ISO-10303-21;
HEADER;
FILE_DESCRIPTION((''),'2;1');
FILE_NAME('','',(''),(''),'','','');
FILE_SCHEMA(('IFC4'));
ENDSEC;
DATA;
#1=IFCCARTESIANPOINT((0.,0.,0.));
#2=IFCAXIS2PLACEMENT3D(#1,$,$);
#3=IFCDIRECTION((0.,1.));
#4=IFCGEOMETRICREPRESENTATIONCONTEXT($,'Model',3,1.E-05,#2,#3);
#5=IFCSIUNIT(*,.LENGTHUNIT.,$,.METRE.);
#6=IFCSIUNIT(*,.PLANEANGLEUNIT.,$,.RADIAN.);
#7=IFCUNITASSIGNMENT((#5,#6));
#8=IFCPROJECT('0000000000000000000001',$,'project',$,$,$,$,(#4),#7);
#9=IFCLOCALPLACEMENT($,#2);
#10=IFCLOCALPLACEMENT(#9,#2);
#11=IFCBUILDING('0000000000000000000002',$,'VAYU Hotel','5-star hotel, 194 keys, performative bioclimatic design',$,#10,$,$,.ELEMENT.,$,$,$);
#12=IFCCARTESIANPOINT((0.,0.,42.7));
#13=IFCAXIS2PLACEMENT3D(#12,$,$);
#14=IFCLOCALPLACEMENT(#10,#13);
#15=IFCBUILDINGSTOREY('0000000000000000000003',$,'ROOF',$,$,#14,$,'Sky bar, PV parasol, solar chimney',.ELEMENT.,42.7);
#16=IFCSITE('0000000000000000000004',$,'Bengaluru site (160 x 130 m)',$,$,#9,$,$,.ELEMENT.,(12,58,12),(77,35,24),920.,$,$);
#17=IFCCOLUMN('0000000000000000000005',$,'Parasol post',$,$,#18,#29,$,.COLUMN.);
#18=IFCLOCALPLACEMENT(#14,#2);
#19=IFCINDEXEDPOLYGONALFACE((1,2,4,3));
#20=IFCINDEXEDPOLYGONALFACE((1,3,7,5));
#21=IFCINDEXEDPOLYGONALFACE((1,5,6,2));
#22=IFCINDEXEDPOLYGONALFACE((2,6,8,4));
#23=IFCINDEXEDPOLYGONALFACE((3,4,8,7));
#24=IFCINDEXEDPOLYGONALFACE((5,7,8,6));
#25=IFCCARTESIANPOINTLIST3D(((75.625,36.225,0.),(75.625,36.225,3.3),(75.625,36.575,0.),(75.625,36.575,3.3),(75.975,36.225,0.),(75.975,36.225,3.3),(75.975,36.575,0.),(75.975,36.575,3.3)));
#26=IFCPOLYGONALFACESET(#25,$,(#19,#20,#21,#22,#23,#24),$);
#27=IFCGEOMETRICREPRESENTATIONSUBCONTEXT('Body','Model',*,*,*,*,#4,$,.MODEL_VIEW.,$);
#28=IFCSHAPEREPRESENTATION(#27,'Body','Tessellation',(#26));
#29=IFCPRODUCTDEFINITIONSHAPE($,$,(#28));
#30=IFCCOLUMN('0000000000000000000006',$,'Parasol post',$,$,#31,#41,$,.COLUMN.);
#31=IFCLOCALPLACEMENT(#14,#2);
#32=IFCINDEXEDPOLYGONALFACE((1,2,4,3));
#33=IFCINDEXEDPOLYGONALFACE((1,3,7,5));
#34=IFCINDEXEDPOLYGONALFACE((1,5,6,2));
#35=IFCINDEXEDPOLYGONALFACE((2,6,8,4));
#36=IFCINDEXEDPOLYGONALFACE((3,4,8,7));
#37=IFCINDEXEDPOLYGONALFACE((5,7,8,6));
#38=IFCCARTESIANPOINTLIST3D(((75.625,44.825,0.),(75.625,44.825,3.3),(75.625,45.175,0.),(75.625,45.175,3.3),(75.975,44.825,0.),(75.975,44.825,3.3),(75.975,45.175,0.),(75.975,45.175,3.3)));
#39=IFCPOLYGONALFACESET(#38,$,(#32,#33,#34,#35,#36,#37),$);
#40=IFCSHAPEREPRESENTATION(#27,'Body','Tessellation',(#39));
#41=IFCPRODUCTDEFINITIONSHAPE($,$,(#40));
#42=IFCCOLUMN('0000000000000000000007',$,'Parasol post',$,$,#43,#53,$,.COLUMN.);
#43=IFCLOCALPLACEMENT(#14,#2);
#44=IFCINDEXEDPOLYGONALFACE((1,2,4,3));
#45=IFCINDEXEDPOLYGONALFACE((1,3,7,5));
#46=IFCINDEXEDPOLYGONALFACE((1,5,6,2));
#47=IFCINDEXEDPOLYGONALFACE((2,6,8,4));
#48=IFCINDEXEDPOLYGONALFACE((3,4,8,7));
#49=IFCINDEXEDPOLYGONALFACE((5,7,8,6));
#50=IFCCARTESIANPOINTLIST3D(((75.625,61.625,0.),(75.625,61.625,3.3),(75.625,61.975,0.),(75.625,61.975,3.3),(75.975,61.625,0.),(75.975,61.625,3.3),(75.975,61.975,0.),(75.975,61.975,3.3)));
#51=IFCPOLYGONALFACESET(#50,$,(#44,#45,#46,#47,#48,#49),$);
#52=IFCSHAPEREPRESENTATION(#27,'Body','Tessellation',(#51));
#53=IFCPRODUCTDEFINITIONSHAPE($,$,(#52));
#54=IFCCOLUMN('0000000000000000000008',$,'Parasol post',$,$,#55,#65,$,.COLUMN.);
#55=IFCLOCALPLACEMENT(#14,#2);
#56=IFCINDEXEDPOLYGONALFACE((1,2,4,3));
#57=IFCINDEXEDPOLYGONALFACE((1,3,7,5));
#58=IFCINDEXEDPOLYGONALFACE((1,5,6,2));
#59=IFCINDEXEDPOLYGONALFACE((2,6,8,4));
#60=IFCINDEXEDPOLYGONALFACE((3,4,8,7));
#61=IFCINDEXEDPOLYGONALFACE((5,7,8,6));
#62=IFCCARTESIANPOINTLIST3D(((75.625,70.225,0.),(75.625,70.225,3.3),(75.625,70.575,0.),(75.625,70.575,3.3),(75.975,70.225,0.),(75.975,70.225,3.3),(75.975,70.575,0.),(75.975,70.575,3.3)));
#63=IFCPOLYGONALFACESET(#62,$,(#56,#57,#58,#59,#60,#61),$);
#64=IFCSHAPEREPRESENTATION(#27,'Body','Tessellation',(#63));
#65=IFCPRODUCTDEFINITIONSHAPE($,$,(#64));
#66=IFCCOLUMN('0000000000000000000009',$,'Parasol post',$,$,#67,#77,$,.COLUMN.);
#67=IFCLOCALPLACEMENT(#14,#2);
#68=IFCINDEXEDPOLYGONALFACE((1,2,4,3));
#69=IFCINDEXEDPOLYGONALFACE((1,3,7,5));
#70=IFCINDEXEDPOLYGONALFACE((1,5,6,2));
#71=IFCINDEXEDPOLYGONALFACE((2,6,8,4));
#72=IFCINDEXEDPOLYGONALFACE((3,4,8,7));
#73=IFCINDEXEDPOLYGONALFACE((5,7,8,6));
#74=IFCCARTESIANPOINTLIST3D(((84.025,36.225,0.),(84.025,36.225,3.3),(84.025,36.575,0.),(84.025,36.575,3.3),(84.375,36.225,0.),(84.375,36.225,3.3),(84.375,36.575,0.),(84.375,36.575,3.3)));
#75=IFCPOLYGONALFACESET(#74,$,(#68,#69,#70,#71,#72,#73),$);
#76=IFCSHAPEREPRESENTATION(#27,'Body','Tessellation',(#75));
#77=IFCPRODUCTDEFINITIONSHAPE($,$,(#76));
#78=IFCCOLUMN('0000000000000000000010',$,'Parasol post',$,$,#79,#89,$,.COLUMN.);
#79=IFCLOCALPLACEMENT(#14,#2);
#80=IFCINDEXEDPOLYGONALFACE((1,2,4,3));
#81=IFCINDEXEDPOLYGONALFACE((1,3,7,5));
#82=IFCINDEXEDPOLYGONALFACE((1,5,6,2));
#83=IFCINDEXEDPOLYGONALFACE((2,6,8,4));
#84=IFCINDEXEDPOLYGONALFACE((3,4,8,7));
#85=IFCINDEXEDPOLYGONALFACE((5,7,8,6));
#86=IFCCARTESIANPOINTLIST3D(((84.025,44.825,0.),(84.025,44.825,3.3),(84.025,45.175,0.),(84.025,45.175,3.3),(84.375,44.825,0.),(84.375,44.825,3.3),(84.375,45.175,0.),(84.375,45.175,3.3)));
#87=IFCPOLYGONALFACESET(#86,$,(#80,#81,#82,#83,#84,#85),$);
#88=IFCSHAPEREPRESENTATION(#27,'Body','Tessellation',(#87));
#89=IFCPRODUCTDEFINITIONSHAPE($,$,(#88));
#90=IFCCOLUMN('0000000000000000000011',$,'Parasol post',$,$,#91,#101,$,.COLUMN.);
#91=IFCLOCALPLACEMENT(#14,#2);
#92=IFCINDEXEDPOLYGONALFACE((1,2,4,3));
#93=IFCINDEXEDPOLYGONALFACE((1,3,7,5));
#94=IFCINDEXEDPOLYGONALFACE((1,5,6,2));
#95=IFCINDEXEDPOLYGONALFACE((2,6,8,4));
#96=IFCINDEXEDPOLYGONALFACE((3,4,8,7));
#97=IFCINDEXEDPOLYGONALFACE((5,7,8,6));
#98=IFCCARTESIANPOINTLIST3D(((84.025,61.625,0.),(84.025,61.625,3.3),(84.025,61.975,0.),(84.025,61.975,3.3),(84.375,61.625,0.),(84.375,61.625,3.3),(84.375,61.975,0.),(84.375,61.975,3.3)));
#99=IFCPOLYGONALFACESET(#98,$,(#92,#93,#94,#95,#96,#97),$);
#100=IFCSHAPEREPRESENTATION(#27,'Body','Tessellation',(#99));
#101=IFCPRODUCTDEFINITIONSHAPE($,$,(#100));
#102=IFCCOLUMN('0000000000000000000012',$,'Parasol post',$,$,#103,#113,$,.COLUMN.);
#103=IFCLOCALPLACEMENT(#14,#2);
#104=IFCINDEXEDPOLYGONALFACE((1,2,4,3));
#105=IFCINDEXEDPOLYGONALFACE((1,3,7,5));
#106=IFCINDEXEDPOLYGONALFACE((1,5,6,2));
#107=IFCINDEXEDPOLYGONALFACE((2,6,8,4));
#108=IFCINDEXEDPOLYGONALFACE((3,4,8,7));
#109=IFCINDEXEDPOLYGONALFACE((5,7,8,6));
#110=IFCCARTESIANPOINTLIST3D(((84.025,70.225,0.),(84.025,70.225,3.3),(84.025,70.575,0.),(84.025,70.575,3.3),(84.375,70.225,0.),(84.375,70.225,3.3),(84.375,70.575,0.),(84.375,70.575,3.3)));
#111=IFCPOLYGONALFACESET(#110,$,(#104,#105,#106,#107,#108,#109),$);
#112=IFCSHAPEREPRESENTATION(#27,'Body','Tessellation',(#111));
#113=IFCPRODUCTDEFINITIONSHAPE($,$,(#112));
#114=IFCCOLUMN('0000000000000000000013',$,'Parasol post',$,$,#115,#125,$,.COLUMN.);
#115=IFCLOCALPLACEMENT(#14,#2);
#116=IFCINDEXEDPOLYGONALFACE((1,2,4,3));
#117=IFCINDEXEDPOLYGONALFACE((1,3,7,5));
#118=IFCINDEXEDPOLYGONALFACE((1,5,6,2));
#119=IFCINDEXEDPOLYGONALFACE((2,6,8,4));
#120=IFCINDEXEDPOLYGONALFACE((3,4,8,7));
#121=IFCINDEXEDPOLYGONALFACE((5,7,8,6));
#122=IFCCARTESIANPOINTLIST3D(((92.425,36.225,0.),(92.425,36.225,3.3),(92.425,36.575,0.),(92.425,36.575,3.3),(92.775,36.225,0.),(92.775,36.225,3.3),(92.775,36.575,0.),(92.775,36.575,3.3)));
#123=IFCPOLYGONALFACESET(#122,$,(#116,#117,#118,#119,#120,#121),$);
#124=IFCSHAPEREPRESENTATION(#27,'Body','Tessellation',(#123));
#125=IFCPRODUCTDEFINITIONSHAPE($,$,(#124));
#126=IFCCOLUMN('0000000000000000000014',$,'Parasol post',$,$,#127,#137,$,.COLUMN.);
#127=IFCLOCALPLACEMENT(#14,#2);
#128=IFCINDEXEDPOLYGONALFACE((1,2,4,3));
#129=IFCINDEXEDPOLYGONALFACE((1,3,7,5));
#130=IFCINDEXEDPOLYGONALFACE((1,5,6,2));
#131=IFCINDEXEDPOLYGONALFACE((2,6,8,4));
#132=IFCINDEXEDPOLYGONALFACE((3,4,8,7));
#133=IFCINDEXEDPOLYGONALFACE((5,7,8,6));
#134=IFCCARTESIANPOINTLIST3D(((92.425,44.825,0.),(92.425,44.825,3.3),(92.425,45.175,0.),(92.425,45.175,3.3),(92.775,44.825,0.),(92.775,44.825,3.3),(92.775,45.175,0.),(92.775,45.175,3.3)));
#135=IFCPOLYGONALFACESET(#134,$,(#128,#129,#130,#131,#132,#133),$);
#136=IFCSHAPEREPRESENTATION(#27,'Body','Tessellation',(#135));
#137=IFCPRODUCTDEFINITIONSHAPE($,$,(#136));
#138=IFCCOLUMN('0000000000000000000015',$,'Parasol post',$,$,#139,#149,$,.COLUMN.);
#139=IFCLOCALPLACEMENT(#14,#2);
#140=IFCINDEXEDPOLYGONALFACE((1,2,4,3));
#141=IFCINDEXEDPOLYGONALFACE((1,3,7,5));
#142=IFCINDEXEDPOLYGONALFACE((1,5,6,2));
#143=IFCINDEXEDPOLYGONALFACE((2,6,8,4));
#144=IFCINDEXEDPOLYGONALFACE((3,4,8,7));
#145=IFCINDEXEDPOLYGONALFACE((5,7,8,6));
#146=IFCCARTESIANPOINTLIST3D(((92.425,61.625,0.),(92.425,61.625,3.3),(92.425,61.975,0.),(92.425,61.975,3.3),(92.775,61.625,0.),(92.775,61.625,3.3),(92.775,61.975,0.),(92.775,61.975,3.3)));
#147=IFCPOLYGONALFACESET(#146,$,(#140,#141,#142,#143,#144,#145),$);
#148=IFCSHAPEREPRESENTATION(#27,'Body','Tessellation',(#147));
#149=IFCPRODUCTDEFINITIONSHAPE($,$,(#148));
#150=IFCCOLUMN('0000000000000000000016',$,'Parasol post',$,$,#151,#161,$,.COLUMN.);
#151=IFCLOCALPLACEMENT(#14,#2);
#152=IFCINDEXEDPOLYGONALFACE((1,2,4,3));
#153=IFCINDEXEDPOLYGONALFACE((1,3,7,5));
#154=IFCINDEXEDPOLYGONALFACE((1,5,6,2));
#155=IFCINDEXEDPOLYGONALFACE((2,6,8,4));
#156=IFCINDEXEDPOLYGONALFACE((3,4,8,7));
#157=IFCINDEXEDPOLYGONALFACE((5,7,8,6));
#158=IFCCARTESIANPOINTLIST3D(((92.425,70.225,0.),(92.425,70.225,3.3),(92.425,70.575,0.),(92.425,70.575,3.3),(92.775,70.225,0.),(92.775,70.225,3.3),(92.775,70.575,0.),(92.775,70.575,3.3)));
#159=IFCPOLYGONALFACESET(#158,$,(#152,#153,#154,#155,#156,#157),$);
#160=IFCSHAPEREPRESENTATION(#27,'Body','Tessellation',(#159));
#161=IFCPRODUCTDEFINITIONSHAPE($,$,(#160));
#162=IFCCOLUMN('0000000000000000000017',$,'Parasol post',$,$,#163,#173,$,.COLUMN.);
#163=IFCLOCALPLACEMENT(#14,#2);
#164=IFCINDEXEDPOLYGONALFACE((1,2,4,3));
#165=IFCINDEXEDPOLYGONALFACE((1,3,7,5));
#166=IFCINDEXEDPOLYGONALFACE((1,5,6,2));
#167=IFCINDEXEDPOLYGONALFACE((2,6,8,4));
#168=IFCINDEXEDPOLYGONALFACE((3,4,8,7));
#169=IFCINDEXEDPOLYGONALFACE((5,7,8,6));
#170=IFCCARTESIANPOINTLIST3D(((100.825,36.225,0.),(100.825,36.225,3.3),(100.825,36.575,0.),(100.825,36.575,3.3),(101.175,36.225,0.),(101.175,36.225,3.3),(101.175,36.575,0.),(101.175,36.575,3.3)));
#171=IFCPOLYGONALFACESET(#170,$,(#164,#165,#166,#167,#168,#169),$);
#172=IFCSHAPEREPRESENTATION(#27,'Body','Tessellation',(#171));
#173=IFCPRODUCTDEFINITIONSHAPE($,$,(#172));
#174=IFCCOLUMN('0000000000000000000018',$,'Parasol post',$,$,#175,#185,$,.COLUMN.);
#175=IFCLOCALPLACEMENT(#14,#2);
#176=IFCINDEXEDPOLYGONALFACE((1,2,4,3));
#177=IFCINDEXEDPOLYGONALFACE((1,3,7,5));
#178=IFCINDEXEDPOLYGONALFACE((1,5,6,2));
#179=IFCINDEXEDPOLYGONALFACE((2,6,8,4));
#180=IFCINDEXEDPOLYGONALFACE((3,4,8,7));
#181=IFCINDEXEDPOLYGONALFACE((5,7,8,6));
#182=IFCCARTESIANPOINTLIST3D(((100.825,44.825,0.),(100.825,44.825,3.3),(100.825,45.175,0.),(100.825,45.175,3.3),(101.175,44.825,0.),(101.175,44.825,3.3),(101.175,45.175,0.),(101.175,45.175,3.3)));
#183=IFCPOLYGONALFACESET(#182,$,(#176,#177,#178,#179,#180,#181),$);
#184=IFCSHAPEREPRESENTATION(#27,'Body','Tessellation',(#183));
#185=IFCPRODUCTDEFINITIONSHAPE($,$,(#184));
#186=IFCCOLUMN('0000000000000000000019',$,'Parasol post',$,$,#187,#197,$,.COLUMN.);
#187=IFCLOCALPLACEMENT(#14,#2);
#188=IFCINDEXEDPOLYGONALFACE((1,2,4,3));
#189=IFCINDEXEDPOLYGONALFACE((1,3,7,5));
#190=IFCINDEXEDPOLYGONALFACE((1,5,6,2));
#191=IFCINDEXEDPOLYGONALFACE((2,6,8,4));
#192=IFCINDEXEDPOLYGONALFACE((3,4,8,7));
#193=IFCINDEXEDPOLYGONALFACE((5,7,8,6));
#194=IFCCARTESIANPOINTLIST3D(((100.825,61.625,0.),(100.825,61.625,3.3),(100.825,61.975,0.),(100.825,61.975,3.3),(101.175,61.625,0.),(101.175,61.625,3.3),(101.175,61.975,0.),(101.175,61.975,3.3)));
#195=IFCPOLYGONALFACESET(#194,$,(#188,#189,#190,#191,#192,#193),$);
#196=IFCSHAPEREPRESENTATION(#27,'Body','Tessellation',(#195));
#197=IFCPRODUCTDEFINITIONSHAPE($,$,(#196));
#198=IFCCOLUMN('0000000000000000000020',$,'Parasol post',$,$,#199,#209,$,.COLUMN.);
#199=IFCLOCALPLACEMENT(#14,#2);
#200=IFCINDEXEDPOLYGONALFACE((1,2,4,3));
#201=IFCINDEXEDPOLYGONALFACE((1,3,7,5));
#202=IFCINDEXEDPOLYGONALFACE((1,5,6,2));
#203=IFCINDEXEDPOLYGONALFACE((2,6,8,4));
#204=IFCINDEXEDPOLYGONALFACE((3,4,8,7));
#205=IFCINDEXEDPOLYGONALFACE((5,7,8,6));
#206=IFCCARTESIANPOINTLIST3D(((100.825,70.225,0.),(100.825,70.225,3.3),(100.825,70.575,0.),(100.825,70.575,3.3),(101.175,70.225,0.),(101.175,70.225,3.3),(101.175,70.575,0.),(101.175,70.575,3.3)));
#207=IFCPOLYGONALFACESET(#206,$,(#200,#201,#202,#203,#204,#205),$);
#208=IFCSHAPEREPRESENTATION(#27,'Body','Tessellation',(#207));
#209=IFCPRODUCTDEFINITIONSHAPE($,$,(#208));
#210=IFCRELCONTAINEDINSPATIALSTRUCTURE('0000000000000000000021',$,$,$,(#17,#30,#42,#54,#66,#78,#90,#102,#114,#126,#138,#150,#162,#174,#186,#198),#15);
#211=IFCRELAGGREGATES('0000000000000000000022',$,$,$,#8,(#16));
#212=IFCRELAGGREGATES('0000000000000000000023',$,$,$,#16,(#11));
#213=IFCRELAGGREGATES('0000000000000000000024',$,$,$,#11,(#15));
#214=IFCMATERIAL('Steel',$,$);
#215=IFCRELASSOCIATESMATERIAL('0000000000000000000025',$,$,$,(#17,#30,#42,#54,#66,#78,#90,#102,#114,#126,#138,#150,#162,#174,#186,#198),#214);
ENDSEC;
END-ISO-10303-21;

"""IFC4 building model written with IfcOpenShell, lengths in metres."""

from ifc_helpers import new_model, si_unit, direction, frame, origin, place, context, subcontext, project, spatial, polyline, outline, extrude, material, element, save


model = new_model("IFC4")

# Units and contexts
model_context = context("Model", 3, precision=1e-05, world=origin(), true_north=direction((0.0, 1.0)))
body_context = subcontext(model_context, "Body", "Model", "MODEL_VIEW")
ifc_project = project(units=[si_unit("LENGTHUNIT", "METRE"), si_unit("PLANEANGLEUNIT", "RADIAN")], contexts=[model_context])

# Site, building, storey
site_placement = place(None, origin())
site = spatial("IfcSite", under=ifc_project, at=site_placement, Name="Bengaluru site (160 x 130 m)", CompositionType="ELEMENT", RefLatitude=(12, 58, 12), RefLongitude=(77, 35, 24), RefElevation=920.0)
building_placement = place(site_placement, origin())
building = spatial("IfcBuilding", under=site, at=building_placement, Name="VAYU Hotel", Description="5-star hotel, 194 keys, performative bioclimatic design", CompositionType="ELEMENT")
storey_placement = place(building_placement, frame((0.0, 0.0, 42.7)))
storey = spatial("IfcBuildingStorey", under=building, at=storey_placement, Name="ROOF", LongName="Sky bar, PV parasol, solar chimney", CompositionType="ELEMENT", Elevation=42.7)

# Columns
ifc_material_1 = material(Name="Steel")
column_1_placement = place(storey_placement, origin())
element("IfcColumn", 1, at=column_1_placement, inside=storey, material=ifc_material_1, Name="Parasol post", PredefinedType="COLUMN", context=body_context, shape_type="SweptSolid", body=[
    extrude(outline(polyline([(75.625, 36.225), (75.975, 36.225), (75.975, 36.575), (75.625, 36.575), (75.625, 36.225)])), origin(), (0.0, 0.0, 1.0), 3.3),
])
column_2_placement = place(storey_placement, origin())
element("IfcColumn", 2, at=column_2_placement, inside=storey, material=ifc_material_1, Name="Parasol post", PredefinedType="COLUMN", context=body_context, shape_type="SweptSolid", body=[
    extrude(outline(polyline([(75.625, 44.825), (75.975, 44.825), (75.975, 45.175), (75.625, 45.175), (75.625, 44.825)])), origin(), (0.0, 0.0, 1.0), 3.3),
])
column_3_placement = place(storey_placement, origin())
element("IfcColumn", 3, at=column_3_placement, inside=storey, material=ifc_material_1, Name="Parasol post", PredefinedType="COLUMN", context=body_context, shape_type="SweptSolid", body=[
    extrude(outline(polyline([(75.625, 61.625), (75.975, 61.625), (75.975, 61.975), (75.625, 61.975), (75.625, 61.625)])), origin(), (0.0, 0.0, 1.0), 3.3),
])
column_4_placement = place(storey_placement, origin())
element("IfcColumn", 4, at=column_4_placement, inside=storey, material=ifc_material_1, Name="Parasol post", PredefinedType="COLUMN", context=body_context, shape_type="SweptSolid", body=[
    extrude(outline(polyline([(75.625, 70.225), (75.975, 70.225), (75.975, 70.575), (75.625, 70.575), (75.625, 70.225)])), origin(), (0.0, 0.0, 1.0), 3.3),
])
column_5_placement = place(storey_placement, origin())
element("IfcColumn", 5, at=column_5_placement, inside=storey, material=ifc_material_1, Name="Parasol post", PredefinedType="COLUMN", context=body_context, shape_type="SweptSolid", body=[
    extrude(outline(polyline([(84.025, 36.225), (84.375, 36.225), (84.375, 36.575), (84.025, 36.575), (84.025, 36.225)])), origin(), (0.0, 0.0, 1.0), 3.3),
])
column_6_placement = place(storey_placement, origin())
element("IfcColumn", 6, at=column_6_placement, inside=storey, material=ifc_material_1, Name="Parasol post", PredefinedType="COLUMN", context=body_context, shape_type="SweptSolid", body=[
    extrude(outline(polyline([(84.025, 44.825), (84.375, 44.825), (84.375, 45.175), (84.025, 45.175), (84.025, 44.825)])), origin(), (0.0, 0.0, 1.0), 3.3),
])
column_7_placement = place(storey_placement, origin())
element("IfcColumn", 7, at=column_7_placement, inside=storey, material=ifc_material_1, Name="Parasol post", PredefinedType="COLUMN", context=body_context, shape_type="SweptSolid", body=[
    extrude(outline(polyline([(84.025, 61.625), (84.375, 61.625), (84.375, 61.975), (84.025, 61.975), (84.025, 61.625)])), origin(), (0.0, 0.0, 1.0), 3.3),
])
column_8_placement = place(storey_placement, origin())
element("IfcColumn", 8, at=column_8_placement, inside=storey, material=ifc_material_1, Name="Parasol post", PredefinedType="COLUMN", context=body_context, shape_type="SweptSolid", body=[
    extrude(outline(polyline([(84.025, 70.225), (84.375, 70.225), (84.375, 70.575), (84.025, 70.575), (84.025, 70.225)])), origin(), (0.0, 0.0, 1.0), 3.3),
])
column_9_placement = place(storey_placement, origin())
element("IfcColumn", 9, at=column_9_placement, inside=storey, material=ifc_material_1, Name="Parasol post", PredefinedType="COLUMN", context=body_context, shape_type="SweptSolid", body=[
    extrude(outline(polyline([(92.425, 36.225), (92.775, 36.225), (92.775, 36.575), (92.425, 36.575), (92.425, 36.225)])), origin(), (0.0, 0.0, 1.0), 3.3),
])
column_10_placement = place(storey_placement, origin())
element("IfcColumn", 10, at=column_10_placement, inside=storey, material=ifc_material_1, Name="Parasol post", PredefinedType="COLUMN", context=body_context, shape_type="SweptSolid", body=[
    extrude(outline(polyline([(92.425, 44.825), (92.775, 44.825), (92.775, 45.175), (92.425, 45.175), (92.425, 44.825)])), origin(), (0.0, 0.0, 1.0), 3.3),
])
column_11_placement = place(storey_placement, origin())
element("IfcColumn", 11, at=column_11_placement, inside=storey, material=ifc_material_1, Name="Parasol post", PredefinedType="COLUMN", context=body_context, shape_type="SweptSolid", body=[
    extrude(outline(polyline([(92.425, 61.625), (92.775, 61.625), (92.775, 61.975), (92.425, 61.975), (92.425, 61.625)])), origin(), (0.0, 0.0, 1.0), 3.3),
])
column_12_placement = place(storey_placement, origin())
element("IfcColumn", 12, at=column_12_placement, inside=storey, material=ifc_material_1, Name="Parasol post", PredefinedType="COLUMN", context=body_context, shape_type="SweptSolid", body=[
    extrude(outline(polyline([(92.425, 70.225), (92.775, 70.225), (92.775, 70.575), (92.425, 70.575), (92.425, 70.225)])), origin(), (0.0, 0.0, 1.0), 3.3),
])
column_13_placement = place(storey_placement, origin())
element("IfcColumn", 13, at=column_13_placement, inside=storey, material=ifc_material_1, Name="Parasol post", PredefinedType="COLUMN", context=body_context, shape_type="SweptSolid", body=[
    extrude(outline(polyline([(100.825, 36.225), (101.175, 36.225), (101.175, 36.575), (100.825, 36.575), (100.825, 36.225)])), origin(), (0.0, 0.0, 1.0), 3.3),
])
column_14_placement = place(storey_placement, origin())
element("IfcColumn", 14, at=column_14_placement, inside=storey, material=ifc_material_1, Name="Parasol post", PredefinedType="COLUMN", context=body_context, shape_type="SweptSolid", body=[
    extrude(outline(polyline([(100.825, 44.825), (101.175, 44.825), (101.175, 45.175), (100.825, 45.175), (100.825, 44.825)])), origin(), (0.0, 0.0, 1.0), 3.3),
])
column_15_placement = place(storey_placement, origin())
element("IfcColumn", 15, at=column_15_placement, inside=storey, material=ifc_material_1, Name="Parasol post", PredefinedType="COLUMN", context=body_context, shape_type="SweptSolid", body=[
    extrude(outline(polyline([(100.825, 61.625), (101.175, 61.625), (101.175, 61.975), (100.825, 61.975), (100.825, 61.625)])), origin(), (0.0, 0.0, 1.0), 3.3),
])
column_16_placement = place(storey_placement, origin())
element("IfcColumn", 16, at=column_16_placement, inside=storey, material=ifc_material_1, Name="Parasol post", PredefinedType="COLUMN", context=body_context, shape_type="SweptSolid", body=[
    extrude(outline(polyline([(100.825, 70.225), (101.175, 70.225), (101.175, 70.575), (100.825, 70.575), (100.825, 70.225)])), origin(), (0.0, 0.0, 1.0), 3.3),
])

save(model, "model.ifc")
